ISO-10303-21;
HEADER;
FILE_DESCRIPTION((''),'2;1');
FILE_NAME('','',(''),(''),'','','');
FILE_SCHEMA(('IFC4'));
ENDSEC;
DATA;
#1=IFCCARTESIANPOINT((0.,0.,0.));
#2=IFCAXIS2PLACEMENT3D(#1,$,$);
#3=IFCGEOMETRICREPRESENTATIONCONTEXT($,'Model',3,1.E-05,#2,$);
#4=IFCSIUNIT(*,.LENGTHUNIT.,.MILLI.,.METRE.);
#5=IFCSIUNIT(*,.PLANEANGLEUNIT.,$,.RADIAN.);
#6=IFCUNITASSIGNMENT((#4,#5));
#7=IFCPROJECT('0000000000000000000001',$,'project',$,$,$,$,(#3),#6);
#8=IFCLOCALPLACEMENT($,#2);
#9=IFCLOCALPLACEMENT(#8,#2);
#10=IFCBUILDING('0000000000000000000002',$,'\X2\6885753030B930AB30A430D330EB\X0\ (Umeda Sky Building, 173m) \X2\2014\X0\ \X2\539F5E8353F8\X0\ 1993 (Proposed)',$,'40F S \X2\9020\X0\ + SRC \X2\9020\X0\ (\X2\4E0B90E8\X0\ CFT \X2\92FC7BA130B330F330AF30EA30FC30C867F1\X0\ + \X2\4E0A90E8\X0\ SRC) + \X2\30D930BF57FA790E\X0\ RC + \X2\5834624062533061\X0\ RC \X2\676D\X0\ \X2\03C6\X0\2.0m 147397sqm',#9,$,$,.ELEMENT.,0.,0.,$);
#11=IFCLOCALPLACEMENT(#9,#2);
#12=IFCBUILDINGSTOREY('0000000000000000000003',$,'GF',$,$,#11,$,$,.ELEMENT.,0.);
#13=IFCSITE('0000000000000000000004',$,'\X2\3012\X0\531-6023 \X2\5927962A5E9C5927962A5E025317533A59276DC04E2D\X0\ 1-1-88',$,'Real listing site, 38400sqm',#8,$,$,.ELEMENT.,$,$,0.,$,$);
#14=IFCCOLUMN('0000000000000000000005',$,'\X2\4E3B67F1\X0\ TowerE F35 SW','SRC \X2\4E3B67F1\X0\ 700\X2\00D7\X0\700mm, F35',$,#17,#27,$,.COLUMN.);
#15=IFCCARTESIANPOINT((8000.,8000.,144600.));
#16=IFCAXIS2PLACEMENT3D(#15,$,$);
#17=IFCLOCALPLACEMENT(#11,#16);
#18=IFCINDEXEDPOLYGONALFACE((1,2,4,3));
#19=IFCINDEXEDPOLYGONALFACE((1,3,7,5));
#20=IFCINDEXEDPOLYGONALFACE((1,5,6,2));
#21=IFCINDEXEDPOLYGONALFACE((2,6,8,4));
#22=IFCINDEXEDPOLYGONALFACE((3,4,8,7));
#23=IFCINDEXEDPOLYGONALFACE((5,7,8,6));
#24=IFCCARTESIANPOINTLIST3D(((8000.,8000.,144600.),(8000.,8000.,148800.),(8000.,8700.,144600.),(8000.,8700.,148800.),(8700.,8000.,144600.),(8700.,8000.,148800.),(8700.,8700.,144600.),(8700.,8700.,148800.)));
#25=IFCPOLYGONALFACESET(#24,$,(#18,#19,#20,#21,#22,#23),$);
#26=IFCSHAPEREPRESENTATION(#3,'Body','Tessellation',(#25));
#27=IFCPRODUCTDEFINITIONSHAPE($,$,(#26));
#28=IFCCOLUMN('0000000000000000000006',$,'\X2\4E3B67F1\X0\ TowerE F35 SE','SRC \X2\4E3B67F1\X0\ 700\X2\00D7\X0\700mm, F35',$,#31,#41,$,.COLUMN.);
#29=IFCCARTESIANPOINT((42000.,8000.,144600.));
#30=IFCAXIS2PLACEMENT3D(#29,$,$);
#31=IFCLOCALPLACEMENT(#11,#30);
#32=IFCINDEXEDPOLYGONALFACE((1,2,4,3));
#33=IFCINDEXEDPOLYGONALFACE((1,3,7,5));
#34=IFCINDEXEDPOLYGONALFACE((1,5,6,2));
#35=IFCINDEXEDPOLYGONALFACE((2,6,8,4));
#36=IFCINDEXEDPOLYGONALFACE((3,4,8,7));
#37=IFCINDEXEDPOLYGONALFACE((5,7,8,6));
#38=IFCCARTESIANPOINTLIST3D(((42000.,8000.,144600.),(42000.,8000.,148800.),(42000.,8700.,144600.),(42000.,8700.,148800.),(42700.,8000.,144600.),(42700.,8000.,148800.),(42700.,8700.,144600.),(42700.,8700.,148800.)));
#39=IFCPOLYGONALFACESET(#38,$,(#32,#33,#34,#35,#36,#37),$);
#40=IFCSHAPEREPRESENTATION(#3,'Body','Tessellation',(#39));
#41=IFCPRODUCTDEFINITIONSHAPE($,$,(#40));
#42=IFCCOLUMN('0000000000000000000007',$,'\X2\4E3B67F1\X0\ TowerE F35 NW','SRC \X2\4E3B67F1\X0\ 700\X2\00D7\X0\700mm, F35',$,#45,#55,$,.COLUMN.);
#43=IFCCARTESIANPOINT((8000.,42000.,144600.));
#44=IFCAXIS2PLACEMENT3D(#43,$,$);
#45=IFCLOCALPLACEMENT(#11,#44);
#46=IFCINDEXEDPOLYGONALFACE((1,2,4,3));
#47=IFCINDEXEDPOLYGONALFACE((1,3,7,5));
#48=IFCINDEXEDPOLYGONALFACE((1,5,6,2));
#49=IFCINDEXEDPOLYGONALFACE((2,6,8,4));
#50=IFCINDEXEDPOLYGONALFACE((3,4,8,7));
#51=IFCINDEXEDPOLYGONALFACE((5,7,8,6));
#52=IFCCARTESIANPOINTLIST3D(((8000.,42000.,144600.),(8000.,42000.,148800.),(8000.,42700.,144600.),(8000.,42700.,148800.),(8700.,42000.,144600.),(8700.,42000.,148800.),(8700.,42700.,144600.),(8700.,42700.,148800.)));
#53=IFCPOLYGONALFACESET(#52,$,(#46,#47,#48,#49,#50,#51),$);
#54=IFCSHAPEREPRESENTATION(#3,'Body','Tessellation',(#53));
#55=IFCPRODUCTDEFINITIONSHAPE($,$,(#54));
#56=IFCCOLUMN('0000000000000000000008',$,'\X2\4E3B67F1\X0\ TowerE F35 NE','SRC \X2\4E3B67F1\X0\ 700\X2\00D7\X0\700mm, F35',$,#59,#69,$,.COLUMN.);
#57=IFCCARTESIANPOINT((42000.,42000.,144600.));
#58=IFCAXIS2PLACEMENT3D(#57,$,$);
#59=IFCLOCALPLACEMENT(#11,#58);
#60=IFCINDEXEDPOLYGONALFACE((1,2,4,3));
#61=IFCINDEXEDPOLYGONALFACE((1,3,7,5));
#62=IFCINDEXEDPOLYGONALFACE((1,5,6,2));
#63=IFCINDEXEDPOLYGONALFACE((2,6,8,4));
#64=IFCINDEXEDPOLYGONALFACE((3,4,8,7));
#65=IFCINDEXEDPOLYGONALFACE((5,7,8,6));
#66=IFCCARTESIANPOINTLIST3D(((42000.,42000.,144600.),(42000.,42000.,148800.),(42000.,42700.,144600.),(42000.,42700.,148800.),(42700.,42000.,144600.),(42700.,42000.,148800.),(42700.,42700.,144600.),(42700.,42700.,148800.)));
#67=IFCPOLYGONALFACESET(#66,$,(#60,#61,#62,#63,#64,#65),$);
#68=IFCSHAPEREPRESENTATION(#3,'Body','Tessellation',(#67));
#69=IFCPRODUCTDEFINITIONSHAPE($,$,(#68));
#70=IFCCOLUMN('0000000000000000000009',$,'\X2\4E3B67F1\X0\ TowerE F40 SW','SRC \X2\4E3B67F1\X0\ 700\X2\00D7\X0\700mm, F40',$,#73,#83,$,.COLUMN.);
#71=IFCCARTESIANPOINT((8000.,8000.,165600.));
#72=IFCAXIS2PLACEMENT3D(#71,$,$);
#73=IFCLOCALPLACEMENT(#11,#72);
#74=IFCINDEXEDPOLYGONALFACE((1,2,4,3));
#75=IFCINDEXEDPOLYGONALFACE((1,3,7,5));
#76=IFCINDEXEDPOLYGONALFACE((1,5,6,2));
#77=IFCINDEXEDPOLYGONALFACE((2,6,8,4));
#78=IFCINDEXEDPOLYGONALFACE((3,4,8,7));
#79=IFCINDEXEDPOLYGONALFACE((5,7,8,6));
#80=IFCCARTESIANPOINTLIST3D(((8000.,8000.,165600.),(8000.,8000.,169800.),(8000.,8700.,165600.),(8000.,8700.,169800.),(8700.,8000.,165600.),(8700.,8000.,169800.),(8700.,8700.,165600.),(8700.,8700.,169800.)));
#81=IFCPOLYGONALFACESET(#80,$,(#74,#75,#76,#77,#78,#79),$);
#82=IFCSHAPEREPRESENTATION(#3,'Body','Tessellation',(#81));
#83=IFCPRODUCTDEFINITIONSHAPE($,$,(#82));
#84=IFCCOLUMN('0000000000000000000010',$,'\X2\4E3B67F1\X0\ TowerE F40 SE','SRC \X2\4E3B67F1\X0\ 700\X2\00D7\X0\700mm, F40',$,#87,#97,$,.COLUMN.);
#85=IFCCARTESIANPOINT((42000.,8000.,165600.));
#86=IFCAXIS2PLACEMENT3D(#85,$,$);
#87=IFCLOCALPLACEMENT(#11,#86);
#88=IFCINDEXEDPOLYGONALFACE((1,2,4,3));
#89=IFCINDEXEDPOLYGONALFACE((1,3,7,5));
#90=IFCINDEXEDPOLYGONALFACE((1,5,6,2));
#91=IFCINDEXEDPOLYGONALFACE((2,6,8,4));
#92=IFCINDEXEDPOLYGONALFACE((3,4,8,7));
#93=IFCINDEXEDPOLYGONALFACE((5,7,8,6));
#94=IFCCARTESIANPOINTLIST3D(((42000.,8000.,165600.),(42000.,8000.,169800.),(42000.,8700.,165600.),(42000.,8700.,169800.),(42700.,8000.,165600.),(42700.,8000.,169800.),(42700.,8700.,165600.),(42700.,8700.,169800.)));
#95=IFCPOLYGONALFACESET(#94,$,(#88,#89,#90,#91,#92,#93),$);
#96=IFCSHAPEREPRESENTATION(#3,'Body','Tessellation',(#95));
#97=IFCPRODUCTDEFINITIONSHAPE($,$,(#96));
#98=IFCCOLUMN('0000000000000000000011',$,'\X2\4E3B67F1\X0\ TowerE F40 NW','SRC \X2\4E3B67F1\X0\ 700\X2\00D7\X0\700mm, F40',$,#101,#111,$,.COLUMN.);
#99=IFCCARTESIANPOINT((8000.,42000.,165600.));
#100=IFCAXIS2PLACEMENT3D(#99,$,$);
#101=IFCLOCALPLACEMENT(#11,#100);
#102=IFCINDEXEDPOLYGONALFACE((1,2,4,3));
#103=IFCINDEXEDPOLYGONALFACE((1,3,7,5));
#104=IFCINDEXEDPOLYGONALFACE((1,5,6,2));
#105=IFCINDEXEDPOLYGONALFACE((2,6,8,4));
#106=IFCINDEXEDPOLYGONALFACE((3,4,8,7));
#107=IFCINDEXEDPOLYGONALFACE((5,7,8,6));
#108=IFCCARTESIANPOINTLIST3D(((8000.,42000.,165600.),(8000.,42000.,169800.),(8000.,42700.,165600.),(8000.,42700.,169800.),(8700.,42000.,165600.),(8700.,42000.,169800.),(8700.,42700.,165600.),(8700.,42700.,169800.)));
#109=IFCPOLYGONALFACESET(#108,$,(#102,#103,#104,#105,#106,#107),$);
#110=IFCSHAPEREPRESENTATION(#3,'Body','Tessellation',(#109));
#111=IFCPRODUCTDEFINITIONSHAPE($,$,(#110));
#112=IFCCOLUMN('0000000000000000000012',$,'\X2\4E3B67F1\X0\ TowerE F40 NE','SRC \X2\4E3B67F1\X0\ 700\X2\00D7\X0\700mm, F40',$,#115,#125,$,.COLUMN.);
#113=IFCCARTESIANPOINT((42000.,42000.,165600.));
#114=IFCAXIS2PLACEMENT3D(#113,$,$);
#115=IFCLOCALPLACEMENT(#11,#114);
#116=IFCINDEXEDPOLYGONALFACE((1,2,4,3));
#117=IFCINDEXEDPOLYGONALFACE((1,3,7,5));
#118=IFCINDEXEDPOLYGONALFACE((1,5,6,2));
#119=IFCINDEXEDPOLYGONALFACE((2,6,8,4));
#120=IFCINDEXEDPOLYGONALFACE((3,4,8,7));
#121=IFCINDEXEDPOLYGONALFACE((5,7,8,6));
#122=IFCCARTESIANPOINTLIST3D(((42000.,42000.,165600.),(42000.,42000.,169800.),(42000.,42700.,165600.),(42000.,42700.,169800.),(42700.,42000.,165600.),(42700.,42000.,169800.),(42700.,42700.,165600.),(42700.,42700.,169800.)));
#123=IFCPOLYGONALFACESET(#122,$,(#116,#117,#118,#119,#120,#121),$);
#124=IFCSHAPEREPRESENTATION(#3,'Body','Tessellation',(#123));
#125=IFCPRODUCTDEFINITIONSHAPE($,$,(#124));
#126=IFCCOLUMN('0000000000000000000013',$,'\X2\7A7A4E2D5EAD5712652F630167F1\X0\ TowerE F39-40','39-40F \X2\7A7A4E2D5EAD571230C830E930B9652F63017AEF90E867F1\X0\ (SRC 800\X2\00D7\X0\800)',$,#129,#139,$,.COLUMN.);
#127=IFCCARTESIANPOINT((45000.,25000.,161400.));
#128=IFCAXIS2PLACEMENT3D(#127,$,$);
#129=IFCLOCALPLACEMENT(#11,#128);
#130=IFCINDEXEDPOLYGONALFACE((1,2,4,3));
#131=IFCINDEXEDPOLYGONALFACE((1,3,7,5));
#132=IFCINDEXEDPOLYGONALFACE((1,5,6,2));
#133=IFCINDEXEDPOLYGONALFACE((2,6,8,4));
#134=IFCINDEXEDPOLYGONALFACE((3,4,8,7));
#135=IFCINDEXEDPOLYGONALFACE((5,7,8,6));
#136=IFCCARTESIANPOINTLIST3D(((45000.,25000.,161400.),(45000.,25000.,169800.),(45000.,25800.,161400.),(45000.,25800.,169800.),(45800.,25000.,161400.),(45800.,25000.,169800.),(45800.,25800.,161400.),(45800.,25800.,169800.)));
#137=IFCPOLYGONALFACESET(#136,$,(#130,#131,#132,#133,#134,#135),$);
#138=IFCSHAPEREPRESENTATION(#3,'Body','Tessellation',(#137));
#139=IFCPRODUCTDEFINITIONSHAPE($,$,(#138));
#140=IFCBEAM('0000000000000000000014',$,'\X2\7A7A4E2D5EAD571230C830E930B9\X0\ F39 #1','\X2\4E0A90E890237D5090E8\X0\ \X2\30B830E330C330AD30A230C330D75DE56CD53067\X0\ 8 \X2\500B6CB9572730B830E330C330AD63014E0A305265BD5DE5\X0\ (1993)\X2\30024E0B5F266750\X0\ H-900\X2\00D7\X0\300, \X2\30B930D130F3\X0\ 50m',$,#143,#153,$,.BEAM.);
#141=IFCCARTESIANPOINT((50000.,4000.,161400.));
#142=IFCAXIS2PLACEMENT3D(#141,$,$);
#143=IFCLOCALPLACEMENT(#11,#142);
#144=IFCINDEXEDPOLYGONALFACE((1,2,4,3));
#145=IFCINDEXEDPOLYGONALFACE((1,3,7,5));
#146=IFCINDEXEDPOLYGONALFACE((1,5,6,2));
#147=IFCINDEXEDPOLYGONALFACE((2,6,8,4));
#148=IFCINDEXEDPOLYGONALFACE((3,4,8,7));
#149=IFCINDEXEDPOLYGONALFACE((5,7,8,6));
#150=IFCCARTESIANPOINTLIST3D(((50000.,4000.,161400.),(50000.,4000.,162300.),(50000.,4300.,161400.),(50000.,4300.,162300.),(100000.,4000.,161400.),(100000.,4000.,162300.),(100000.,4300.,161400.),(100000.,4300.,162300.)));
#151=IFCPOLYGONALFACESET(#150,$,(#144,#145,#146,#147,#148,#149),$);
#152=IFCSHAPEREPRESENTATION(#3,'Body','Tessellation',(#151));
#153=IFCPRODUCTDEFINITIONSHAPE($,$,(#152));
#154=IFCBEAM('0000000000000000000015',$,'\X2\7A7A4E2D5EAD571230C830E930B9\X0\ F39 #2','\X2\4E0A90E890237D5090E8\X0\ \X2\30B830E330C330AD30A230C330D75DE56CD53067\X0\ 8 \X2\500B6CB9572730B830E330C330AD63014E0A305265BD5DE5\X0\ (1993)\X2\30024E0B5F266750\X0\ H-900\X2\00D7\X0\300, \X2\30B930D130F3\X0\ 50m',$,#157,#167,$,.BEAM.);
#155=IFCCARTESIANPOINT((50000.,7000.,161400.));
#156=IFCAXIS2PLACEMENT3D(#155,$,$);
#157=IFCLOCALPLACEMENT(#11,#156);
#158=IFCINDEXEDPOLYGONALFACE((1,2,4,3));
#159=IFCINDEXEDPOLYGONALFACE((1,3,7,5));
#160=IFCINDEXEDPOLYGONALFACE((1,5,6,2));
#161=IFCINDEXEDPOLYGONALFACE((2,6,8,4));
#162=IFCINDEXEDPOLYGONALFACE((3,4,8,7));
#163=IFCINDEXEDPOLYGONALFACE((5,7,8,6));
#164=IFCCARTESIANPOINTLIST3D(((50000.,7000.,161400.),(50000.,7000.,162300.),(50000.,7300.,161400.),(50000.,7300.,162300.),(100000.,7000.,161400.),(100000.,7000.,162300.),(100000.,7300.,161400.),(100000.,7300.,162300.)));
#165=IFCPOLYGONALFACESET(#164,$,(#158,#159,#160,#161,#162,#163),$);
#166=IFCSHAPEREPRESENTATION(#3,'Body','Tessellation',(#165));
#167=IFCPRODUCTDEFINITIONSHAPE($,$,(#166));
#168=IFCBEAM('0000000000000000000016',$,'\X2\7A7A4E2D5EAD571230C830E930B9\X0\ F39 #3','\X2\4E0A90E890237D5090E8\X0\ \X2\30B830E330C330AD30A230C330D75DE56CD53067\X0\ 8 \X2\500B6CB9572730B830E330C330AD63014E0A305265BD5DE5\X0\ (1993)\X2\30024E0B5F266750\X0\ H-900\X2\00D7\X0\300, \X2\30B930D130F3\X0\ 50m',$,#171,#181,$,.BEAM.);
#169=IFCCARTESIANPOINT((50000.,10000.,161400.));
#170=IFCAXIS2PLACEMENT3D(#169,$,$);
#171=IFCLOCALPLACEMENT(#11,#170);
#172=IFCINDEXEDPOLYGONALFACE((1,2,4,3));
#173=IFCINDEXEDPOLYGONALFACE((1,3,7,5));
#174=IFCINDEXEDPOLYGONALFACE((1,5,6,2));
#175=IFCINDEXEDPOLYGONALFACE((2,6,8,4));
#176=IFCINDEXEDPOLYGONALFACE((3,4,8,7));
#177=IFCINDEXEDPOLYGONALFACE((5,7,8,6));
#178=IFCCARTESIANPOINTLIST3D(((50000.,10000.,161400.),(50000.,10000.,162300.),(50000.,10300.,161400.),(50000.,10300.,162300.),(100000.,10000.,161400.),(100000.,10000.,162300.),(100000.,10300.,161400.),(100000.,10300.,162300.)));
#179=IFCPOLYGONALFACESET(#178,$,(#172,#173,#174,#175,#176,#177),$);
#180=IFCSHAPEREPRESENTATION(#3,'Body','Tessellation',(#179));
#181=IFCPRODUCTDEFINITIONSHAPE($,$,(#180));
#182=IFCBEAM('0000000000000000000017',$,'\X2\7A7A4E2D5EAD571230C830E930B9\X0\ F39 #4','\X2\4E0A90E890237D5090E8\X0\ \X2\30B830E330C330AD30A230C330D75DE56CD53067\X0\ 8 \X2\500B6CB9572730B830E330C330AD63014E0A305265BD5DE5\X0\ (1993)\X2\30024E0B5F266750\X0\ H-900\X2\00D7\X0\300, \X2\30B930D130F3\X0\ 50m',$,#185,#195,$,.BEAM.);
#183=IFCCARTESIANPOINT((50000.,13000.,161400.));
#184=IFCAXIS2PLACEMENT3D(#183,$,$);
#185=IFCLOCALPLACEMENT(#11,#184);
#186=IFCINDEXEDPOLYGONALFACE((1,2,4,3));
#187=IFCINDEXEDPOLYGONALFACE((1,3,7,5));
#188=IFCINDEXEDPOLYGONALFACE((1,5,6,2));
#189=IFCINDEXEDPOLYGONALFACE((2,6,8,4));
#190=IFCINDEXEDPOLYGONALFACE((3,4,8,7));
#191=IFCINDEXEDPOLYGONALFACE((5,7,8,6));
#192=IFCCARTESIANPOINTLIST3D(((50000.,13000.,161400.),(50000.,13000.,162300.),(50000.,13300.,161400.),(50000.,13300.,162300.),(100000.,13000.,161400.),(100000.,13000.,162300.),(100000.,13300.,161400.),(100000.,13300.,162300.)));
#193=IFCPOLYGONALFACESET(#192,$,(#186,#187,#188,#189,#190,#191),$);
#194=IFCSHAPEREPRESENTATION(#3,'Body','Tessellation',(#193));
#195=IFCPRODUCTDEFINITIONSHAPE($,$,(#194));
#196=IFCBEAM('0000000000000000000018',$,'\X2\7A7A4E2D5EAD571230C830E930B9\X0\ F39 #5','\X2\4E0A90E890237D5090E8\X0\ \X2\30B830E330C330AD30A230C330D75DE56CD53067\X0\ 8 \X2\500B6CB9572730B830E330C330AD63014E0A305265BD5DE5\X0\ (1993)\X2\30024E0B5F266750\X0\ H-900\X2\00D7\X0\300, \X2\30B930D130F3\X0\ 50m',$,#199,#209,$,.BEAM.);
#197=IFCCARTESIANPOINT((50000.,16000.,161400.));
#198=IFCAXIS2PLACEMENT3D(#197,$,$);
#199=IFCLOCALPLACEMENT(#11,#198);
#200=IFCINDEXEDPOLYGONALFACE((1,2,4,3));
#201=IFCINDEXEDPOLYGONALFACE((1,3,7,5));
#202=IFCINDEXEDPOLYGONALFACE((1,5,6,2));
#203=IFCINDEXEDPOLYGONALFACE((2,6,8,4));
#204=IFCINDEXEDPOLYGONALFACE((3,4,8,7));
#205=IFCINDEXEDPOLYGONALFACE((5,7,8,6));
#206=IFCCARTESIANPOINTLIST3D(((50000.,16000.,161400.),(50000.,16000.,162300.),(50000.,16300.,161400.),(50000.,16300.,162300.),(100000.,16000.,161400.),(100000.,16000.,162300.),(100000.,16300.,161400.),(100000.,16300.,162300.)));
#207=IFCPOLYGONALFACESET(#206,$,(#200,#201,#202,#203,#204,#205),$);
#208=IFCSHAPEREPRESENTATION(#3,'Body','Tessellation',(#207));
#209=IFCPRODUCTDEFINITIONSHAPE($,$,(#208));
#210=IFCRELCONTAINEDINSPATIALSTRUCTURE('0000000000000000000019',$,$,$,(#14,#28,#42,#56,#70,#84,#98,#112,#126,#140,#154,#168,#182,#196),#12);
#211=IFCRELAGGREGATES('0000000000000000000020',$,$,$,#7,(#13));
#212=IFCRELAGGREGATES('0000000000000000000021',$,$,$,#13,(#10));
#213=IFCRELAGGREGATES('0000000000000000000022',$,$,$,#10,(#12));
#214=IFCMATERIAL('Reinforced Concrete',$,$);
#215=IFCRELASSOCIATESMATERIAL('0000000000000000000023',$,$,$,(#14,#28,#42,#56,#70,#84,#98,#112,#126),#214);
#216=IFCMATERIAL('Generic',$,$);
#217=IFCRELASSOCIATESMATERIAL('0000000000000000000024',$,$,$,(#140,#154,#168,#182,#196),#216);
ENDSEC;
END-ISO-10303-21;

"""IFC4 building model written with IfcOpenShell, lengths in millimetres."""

from ifc_helpers import new_model, si_unit, frame, frame_2d, origin, place, context, project, spatial, rectangle, extrude, material, element, save


model = new_model("IFC4")

# Units and contexts
model_context = context("Model", 3, precision=1e-05, world=origin())
ifc_project = project(units=[si_unit("LENGTHUNIT", "METRE", prefix="MILLI"), si_unit("PLANEANGLEUNIT", "RADIAN")], contexts=[model_context])

# Site, building, storey
site_placement = place(None, origin())
site = spatial("IfcSite", under=ifc_project, at=site_placement, Name="〒531-6023 大阪府大阪市北区大淀中 1-1-88", ObjectType="Real listing site, 38400sqm", CompositionType="ELEMENT", RefElevation=0.0)
building_placement = place(site_placement, origin())
building = spatial("IfcBuilding", under=site, at=building_placement, Name="梅田スカイビル (Umeda Sky Building, 173m) — 原広司 1993 (Proposed)", ObjectType="40F S 造 + SRC 造 (下部 CFT 鋼管コンクリート柱 + 上部 SRC) + ベタ基礎 RC + 場所打ち RC 杭 φ2.0m 147397sqm", CompositionType="ELEMENT", ElevationOfRefHeight=0.0, ElevationOfTerrain=0.0)
storey_placement = place(building_placement, origin())
storey = spatial("IfcBuildingStorey", under=building, at=storey_placement, Name="GF", CompositionType="ELEMENT", Elevation=0.0)

# Columns
ifc_material_1 = material(Name="Reinforced Concrete")
column_1_placement = place(storey_placement, frame((8000.0, 8000.0, 144600.0)))
element("IfcColumn", 1, at=column_1_placement, inside=storey, material=ifc_material_1, Name="主柱 TowerE F35 SW", Description="SRC 主柱 700×700mm, F35", PredefinedType="COLUMN", context=model_context, shape_type="SweptSolid", body=[
    extrude(rectangle(XDim=700.0, YDim=700.0, at=frame_2d((350.0, 350.0))), frame((8000.0, 8000.0, 144600.0)), (0.0, 0.0, 1.0), 4200.0),
])
column_2_placement = place(storey_placement, frame((42000.0, 8000.0, 144600.0)))
element("IfcColumn", 2, at=column_2_placement, inside=storey, material=ifc_material_1, Name="主柱 TowerE F35 SE", Description="SRC 主柱 700×700mm, F35", PredefinedType="COLUMN", context=model_context, shape_type="SweptSolid", body=[
    extrude(rectangle(XDim=700.0, YDim=700.0, at=frame_2d((350.0, 350.0))), frame((42000.0, 8000.0, 144600.0)), (0.0, 0.0, 1.0), 4200.0),
])
column_3_placement = place(storey_placement, frame((8000.0, 42000.0, 144600.0)))
element("IfcColumn", 3, at=column_3_placement, inside=storey, material=ifc_material_1, Name="主柱 TowerE F35 NW", Description="SRC 主柱 700×700mm, F35", PredefinedType="COLUMN", context=model_context, shape_type="SweptSolid", body=[
    extrude(rectangle(XDim=700.0, YDim=700.0, at=frame_2d((350.0, 350.0))), frame((8000.0, 42000.0, 144600.0)), (0.0, 0.0, 1.0), 4200.0),
])
column_4_placement = place(storey_placement, frame((42000.0, 42000.0, 144600.0)))
element("IfcColumn", 4, at=column_4_placement, inside=storey, material=ifc_material_1, Name="主柱 TowerE F35 NE", Description="SRC 主柱 700×700mm, F35", PredefinedType="COLUMN", context=model_context, shape_type="SweptSolid", body=[
    extrude(rectangle(XDim=700.0, YDim=700.0, at=frame_2d((350.0, 350.0))), frame((42000.0, 42000.0, 144600.0)), (0.0, 0.0, 1.0), 4200.0),
])
column_5_placement = place(storey_placement, frame((8000.0, 8000.0, 165600.0)))
element("IfcColumn", 5, at=column_5_placement, inside=storey, material=ifc_material_1, Name="主柱 TowerE F40 SW", Description="SRC 主柱 700×700mm, F40", PredefinedType="COLUMN", context=model_context, shape_type="SweptSolid", body=[
    extrude(rectangle(XDim=700.0, YDim=700.0, at=frame_2d((350.0, 350.0))), frame((8000.0, 8000.0, 165600.0)), (0.0, 0.0, 1.0), 4200.0),
])
column_6_placement = place(storey_placement, frame((42000.0, 8000.0, 165600.0)))
element("IfcColumn", 6, at=column_6_placement, inside=storey, material=ifc_material_1, Name="主柱 TowerE F40 SE", Description="SRC 主柱 700×700mm, F40", PredefinedType="COLUMN", context=model_context, shape_type="SweptSolid", body=[
    extrude(rectangle(XDim=700.0, YDim=700.0, at=frame_2d((350.0, 350.0))), frame((42000.0, 8000.0, 165600.0)), (0.0, 0.0, 1.0), 4200.0),
])
column_7_placement = place(storey_placement, frame((8000.0, 42000.0, 165600.0)))
element("IfcColumn", 7, at=column_7_placement, inside=storey, material=ifc_material_1, Name="主柱 TowerE F40 NW", Description="SRC 主柱 700×700mm, F40", PredefinedType="COLUMN", context=model_context, shape_type="SweptSolid", body=[
    extrude(rectangle(XDim=700.0, YDim=700.0, at=frame_2d((350.0, 350.0))), frame((8000.0, 42000.0, 165600.0)), (0.0, 0.0, 1.0), 4200.0),
])
column_8_placement = place(storey_placement, frame((42000.0, 42000.0, 165600.0)))
element("IfcColumn", 8, at=column_8_placement, inside=storey, material=ifc_material_1, Name="主柱 TowerE F40 NE", Description="SRC 主柱 700×700mm, F40", PredefinedType="COLUMN", context=model_context, shape_type="SweptSolid", body=[
    extrude(rectangle(XDim=700.0, YDim=700.0, at=frame_2d((350.0, 350.0))), frame((42000.0, 42000.0, 165600.0)), (0.0, 0.0, 1.0), 4200.0),
])
column_9_placement = place(storey_placement, frame((45000.0, 25000.0, 161400.0)))
element("IfcColumn", 9, at=column_9_placement, inside=storey, material=ifc_material_1, Name="空中庭園支持柱 TowerE F39-40", Description="39-40F 空中庭園トラス支持端部柱 (SRC 800×800)", PredefinedType="COLUMN", context=model_context, shape_type="SweptSolid", body=[
    extrude(rectangle(XDim=800.0, YDim=800.0, at=frame_2d((400.0, 400.0))), frame((45000.0, 25000.0, 161400.0)), (0.0, 0.0, 1.0), 8400.0),
])

# Beams
ifc_material_2 = material(Name="Generic")
beam_1_placement = place(storey_placement, frame((50000.0, 4000.0, 161400.0)))
element("IfcBeam", 10, at=beam_1_placement, inside=storey, material=ifc_material_2, Name="空中庭園トラス F39 #1", Description="上部連結部 ジャッキアップ工法で 8 個油圧ジャッキ持上げ施工 (1993)。下弦材 H-900×300, スパン 50m", PredefinedType="BEAM", context=model_context, shape_type="SweptSolid", body=[
    extrude(rectangle(XDim=50000.0, YDim=300.0, at=frame_2d((25000.0, 150.0))), frame((50000.0, 4000.0, 161400.0)), (0.0, 0.0, 1.0), 900.0),
])
beam_2_placement = place(storey_placement, frame((50000.0, 7000.0, 161400.0)))
element("IfcBeam", 11, at=beam_2_placement, inside=storey, material=ifc_material_2, Name="空中庭園トラス F39 #2", Description="上部連結部 ジャッキアップ工法で 8 個油圧ジャッキ持上げ施工 (1993)。下弦材 H-900×300, スパン 50m", PredefinedType="BEAM", context=model_context, shape_type="SweptSolid", body=[
    extrude(rectangle(XDim=50000.0, YDim=300.0, at=frame_2d((25000.0, 150.0))), frame((50000.0, 7000.0, 161400.0)), (0.0, 0.0, 1.0), 900.0),
])
beam_3_placement = place(storey_placement, frame((50000.0, 10000.0, 161400.0)))
element("IfcBeam", 12, at=beam_3_placement, inside=storey, material=ifc_material_2, Name="空中庭園トラス F39 #3", Description="上部連結部 ジャッキアップ工法で 8 個油圧ジャッキ持上げ施工 (1993)。下弦材 H-900×300, スパン 50m", PredefinedType="BEAM", context=model_context, shape_type="SweptSolid", body=[
    extrude(rectangle(XDim=50000.0, YDim=300.0, at=frame_2d((25000.0, 150.0))), frame((50000.0, 10000.0, 161400.0)), (0.0, 0.0, 1.0), 900.0),
])
beam_4_placement = place(storey_placement, frame((50000.0, 13000.0, 161400.0)))
element("IfcBeam", 13, at=beam_4_placement, inside=storey, material=ifc_material_2, Name="空中庭園トラス F39 #4", Description="上部連結部 ジャッキアップ工法で 8 個油圧ジャッキ持上げ施工 (1993)。下弦材 H-900×300, スパン 50m", PredefinedType="BEAM", context=model_context, shape_type="SweptSolid", body=[
    extrude(rectangle(XDim=50000.0, YDim=300.0, at=frame_2d((25000.0, 150.0))), frame((50000.0, 13000.0, 161400.0)), (0.0, 0.0, 1.0), 900.0),
])
beam_5_placement = place(storey_placement, frame((50000.0, 16000.0, 161400.0)))
element("IfcBeam", 14, at=beam_5_placement, inside=storey, material=ifc_material_2, Name="空中庭園トラス F39 #5", Description="上部連結部 ジャッキアップ工法で 8 個油圧ジャッキ持上げ施工 (1993)。下弦材 H-900×300, スパン 50m", PredefinedType="BEAM", context=model_context, shape_type="SweptSolid", body=[
    extrude(rectangle(XDim=50000.0, YDim=300.0, at=frame_2d((25000.0, 150.0))), frame((50000.0, 16000.0, 161400.0)), (0.0, 0.0, 1.0), 900.0),
])

save(model, "model.ifc")
